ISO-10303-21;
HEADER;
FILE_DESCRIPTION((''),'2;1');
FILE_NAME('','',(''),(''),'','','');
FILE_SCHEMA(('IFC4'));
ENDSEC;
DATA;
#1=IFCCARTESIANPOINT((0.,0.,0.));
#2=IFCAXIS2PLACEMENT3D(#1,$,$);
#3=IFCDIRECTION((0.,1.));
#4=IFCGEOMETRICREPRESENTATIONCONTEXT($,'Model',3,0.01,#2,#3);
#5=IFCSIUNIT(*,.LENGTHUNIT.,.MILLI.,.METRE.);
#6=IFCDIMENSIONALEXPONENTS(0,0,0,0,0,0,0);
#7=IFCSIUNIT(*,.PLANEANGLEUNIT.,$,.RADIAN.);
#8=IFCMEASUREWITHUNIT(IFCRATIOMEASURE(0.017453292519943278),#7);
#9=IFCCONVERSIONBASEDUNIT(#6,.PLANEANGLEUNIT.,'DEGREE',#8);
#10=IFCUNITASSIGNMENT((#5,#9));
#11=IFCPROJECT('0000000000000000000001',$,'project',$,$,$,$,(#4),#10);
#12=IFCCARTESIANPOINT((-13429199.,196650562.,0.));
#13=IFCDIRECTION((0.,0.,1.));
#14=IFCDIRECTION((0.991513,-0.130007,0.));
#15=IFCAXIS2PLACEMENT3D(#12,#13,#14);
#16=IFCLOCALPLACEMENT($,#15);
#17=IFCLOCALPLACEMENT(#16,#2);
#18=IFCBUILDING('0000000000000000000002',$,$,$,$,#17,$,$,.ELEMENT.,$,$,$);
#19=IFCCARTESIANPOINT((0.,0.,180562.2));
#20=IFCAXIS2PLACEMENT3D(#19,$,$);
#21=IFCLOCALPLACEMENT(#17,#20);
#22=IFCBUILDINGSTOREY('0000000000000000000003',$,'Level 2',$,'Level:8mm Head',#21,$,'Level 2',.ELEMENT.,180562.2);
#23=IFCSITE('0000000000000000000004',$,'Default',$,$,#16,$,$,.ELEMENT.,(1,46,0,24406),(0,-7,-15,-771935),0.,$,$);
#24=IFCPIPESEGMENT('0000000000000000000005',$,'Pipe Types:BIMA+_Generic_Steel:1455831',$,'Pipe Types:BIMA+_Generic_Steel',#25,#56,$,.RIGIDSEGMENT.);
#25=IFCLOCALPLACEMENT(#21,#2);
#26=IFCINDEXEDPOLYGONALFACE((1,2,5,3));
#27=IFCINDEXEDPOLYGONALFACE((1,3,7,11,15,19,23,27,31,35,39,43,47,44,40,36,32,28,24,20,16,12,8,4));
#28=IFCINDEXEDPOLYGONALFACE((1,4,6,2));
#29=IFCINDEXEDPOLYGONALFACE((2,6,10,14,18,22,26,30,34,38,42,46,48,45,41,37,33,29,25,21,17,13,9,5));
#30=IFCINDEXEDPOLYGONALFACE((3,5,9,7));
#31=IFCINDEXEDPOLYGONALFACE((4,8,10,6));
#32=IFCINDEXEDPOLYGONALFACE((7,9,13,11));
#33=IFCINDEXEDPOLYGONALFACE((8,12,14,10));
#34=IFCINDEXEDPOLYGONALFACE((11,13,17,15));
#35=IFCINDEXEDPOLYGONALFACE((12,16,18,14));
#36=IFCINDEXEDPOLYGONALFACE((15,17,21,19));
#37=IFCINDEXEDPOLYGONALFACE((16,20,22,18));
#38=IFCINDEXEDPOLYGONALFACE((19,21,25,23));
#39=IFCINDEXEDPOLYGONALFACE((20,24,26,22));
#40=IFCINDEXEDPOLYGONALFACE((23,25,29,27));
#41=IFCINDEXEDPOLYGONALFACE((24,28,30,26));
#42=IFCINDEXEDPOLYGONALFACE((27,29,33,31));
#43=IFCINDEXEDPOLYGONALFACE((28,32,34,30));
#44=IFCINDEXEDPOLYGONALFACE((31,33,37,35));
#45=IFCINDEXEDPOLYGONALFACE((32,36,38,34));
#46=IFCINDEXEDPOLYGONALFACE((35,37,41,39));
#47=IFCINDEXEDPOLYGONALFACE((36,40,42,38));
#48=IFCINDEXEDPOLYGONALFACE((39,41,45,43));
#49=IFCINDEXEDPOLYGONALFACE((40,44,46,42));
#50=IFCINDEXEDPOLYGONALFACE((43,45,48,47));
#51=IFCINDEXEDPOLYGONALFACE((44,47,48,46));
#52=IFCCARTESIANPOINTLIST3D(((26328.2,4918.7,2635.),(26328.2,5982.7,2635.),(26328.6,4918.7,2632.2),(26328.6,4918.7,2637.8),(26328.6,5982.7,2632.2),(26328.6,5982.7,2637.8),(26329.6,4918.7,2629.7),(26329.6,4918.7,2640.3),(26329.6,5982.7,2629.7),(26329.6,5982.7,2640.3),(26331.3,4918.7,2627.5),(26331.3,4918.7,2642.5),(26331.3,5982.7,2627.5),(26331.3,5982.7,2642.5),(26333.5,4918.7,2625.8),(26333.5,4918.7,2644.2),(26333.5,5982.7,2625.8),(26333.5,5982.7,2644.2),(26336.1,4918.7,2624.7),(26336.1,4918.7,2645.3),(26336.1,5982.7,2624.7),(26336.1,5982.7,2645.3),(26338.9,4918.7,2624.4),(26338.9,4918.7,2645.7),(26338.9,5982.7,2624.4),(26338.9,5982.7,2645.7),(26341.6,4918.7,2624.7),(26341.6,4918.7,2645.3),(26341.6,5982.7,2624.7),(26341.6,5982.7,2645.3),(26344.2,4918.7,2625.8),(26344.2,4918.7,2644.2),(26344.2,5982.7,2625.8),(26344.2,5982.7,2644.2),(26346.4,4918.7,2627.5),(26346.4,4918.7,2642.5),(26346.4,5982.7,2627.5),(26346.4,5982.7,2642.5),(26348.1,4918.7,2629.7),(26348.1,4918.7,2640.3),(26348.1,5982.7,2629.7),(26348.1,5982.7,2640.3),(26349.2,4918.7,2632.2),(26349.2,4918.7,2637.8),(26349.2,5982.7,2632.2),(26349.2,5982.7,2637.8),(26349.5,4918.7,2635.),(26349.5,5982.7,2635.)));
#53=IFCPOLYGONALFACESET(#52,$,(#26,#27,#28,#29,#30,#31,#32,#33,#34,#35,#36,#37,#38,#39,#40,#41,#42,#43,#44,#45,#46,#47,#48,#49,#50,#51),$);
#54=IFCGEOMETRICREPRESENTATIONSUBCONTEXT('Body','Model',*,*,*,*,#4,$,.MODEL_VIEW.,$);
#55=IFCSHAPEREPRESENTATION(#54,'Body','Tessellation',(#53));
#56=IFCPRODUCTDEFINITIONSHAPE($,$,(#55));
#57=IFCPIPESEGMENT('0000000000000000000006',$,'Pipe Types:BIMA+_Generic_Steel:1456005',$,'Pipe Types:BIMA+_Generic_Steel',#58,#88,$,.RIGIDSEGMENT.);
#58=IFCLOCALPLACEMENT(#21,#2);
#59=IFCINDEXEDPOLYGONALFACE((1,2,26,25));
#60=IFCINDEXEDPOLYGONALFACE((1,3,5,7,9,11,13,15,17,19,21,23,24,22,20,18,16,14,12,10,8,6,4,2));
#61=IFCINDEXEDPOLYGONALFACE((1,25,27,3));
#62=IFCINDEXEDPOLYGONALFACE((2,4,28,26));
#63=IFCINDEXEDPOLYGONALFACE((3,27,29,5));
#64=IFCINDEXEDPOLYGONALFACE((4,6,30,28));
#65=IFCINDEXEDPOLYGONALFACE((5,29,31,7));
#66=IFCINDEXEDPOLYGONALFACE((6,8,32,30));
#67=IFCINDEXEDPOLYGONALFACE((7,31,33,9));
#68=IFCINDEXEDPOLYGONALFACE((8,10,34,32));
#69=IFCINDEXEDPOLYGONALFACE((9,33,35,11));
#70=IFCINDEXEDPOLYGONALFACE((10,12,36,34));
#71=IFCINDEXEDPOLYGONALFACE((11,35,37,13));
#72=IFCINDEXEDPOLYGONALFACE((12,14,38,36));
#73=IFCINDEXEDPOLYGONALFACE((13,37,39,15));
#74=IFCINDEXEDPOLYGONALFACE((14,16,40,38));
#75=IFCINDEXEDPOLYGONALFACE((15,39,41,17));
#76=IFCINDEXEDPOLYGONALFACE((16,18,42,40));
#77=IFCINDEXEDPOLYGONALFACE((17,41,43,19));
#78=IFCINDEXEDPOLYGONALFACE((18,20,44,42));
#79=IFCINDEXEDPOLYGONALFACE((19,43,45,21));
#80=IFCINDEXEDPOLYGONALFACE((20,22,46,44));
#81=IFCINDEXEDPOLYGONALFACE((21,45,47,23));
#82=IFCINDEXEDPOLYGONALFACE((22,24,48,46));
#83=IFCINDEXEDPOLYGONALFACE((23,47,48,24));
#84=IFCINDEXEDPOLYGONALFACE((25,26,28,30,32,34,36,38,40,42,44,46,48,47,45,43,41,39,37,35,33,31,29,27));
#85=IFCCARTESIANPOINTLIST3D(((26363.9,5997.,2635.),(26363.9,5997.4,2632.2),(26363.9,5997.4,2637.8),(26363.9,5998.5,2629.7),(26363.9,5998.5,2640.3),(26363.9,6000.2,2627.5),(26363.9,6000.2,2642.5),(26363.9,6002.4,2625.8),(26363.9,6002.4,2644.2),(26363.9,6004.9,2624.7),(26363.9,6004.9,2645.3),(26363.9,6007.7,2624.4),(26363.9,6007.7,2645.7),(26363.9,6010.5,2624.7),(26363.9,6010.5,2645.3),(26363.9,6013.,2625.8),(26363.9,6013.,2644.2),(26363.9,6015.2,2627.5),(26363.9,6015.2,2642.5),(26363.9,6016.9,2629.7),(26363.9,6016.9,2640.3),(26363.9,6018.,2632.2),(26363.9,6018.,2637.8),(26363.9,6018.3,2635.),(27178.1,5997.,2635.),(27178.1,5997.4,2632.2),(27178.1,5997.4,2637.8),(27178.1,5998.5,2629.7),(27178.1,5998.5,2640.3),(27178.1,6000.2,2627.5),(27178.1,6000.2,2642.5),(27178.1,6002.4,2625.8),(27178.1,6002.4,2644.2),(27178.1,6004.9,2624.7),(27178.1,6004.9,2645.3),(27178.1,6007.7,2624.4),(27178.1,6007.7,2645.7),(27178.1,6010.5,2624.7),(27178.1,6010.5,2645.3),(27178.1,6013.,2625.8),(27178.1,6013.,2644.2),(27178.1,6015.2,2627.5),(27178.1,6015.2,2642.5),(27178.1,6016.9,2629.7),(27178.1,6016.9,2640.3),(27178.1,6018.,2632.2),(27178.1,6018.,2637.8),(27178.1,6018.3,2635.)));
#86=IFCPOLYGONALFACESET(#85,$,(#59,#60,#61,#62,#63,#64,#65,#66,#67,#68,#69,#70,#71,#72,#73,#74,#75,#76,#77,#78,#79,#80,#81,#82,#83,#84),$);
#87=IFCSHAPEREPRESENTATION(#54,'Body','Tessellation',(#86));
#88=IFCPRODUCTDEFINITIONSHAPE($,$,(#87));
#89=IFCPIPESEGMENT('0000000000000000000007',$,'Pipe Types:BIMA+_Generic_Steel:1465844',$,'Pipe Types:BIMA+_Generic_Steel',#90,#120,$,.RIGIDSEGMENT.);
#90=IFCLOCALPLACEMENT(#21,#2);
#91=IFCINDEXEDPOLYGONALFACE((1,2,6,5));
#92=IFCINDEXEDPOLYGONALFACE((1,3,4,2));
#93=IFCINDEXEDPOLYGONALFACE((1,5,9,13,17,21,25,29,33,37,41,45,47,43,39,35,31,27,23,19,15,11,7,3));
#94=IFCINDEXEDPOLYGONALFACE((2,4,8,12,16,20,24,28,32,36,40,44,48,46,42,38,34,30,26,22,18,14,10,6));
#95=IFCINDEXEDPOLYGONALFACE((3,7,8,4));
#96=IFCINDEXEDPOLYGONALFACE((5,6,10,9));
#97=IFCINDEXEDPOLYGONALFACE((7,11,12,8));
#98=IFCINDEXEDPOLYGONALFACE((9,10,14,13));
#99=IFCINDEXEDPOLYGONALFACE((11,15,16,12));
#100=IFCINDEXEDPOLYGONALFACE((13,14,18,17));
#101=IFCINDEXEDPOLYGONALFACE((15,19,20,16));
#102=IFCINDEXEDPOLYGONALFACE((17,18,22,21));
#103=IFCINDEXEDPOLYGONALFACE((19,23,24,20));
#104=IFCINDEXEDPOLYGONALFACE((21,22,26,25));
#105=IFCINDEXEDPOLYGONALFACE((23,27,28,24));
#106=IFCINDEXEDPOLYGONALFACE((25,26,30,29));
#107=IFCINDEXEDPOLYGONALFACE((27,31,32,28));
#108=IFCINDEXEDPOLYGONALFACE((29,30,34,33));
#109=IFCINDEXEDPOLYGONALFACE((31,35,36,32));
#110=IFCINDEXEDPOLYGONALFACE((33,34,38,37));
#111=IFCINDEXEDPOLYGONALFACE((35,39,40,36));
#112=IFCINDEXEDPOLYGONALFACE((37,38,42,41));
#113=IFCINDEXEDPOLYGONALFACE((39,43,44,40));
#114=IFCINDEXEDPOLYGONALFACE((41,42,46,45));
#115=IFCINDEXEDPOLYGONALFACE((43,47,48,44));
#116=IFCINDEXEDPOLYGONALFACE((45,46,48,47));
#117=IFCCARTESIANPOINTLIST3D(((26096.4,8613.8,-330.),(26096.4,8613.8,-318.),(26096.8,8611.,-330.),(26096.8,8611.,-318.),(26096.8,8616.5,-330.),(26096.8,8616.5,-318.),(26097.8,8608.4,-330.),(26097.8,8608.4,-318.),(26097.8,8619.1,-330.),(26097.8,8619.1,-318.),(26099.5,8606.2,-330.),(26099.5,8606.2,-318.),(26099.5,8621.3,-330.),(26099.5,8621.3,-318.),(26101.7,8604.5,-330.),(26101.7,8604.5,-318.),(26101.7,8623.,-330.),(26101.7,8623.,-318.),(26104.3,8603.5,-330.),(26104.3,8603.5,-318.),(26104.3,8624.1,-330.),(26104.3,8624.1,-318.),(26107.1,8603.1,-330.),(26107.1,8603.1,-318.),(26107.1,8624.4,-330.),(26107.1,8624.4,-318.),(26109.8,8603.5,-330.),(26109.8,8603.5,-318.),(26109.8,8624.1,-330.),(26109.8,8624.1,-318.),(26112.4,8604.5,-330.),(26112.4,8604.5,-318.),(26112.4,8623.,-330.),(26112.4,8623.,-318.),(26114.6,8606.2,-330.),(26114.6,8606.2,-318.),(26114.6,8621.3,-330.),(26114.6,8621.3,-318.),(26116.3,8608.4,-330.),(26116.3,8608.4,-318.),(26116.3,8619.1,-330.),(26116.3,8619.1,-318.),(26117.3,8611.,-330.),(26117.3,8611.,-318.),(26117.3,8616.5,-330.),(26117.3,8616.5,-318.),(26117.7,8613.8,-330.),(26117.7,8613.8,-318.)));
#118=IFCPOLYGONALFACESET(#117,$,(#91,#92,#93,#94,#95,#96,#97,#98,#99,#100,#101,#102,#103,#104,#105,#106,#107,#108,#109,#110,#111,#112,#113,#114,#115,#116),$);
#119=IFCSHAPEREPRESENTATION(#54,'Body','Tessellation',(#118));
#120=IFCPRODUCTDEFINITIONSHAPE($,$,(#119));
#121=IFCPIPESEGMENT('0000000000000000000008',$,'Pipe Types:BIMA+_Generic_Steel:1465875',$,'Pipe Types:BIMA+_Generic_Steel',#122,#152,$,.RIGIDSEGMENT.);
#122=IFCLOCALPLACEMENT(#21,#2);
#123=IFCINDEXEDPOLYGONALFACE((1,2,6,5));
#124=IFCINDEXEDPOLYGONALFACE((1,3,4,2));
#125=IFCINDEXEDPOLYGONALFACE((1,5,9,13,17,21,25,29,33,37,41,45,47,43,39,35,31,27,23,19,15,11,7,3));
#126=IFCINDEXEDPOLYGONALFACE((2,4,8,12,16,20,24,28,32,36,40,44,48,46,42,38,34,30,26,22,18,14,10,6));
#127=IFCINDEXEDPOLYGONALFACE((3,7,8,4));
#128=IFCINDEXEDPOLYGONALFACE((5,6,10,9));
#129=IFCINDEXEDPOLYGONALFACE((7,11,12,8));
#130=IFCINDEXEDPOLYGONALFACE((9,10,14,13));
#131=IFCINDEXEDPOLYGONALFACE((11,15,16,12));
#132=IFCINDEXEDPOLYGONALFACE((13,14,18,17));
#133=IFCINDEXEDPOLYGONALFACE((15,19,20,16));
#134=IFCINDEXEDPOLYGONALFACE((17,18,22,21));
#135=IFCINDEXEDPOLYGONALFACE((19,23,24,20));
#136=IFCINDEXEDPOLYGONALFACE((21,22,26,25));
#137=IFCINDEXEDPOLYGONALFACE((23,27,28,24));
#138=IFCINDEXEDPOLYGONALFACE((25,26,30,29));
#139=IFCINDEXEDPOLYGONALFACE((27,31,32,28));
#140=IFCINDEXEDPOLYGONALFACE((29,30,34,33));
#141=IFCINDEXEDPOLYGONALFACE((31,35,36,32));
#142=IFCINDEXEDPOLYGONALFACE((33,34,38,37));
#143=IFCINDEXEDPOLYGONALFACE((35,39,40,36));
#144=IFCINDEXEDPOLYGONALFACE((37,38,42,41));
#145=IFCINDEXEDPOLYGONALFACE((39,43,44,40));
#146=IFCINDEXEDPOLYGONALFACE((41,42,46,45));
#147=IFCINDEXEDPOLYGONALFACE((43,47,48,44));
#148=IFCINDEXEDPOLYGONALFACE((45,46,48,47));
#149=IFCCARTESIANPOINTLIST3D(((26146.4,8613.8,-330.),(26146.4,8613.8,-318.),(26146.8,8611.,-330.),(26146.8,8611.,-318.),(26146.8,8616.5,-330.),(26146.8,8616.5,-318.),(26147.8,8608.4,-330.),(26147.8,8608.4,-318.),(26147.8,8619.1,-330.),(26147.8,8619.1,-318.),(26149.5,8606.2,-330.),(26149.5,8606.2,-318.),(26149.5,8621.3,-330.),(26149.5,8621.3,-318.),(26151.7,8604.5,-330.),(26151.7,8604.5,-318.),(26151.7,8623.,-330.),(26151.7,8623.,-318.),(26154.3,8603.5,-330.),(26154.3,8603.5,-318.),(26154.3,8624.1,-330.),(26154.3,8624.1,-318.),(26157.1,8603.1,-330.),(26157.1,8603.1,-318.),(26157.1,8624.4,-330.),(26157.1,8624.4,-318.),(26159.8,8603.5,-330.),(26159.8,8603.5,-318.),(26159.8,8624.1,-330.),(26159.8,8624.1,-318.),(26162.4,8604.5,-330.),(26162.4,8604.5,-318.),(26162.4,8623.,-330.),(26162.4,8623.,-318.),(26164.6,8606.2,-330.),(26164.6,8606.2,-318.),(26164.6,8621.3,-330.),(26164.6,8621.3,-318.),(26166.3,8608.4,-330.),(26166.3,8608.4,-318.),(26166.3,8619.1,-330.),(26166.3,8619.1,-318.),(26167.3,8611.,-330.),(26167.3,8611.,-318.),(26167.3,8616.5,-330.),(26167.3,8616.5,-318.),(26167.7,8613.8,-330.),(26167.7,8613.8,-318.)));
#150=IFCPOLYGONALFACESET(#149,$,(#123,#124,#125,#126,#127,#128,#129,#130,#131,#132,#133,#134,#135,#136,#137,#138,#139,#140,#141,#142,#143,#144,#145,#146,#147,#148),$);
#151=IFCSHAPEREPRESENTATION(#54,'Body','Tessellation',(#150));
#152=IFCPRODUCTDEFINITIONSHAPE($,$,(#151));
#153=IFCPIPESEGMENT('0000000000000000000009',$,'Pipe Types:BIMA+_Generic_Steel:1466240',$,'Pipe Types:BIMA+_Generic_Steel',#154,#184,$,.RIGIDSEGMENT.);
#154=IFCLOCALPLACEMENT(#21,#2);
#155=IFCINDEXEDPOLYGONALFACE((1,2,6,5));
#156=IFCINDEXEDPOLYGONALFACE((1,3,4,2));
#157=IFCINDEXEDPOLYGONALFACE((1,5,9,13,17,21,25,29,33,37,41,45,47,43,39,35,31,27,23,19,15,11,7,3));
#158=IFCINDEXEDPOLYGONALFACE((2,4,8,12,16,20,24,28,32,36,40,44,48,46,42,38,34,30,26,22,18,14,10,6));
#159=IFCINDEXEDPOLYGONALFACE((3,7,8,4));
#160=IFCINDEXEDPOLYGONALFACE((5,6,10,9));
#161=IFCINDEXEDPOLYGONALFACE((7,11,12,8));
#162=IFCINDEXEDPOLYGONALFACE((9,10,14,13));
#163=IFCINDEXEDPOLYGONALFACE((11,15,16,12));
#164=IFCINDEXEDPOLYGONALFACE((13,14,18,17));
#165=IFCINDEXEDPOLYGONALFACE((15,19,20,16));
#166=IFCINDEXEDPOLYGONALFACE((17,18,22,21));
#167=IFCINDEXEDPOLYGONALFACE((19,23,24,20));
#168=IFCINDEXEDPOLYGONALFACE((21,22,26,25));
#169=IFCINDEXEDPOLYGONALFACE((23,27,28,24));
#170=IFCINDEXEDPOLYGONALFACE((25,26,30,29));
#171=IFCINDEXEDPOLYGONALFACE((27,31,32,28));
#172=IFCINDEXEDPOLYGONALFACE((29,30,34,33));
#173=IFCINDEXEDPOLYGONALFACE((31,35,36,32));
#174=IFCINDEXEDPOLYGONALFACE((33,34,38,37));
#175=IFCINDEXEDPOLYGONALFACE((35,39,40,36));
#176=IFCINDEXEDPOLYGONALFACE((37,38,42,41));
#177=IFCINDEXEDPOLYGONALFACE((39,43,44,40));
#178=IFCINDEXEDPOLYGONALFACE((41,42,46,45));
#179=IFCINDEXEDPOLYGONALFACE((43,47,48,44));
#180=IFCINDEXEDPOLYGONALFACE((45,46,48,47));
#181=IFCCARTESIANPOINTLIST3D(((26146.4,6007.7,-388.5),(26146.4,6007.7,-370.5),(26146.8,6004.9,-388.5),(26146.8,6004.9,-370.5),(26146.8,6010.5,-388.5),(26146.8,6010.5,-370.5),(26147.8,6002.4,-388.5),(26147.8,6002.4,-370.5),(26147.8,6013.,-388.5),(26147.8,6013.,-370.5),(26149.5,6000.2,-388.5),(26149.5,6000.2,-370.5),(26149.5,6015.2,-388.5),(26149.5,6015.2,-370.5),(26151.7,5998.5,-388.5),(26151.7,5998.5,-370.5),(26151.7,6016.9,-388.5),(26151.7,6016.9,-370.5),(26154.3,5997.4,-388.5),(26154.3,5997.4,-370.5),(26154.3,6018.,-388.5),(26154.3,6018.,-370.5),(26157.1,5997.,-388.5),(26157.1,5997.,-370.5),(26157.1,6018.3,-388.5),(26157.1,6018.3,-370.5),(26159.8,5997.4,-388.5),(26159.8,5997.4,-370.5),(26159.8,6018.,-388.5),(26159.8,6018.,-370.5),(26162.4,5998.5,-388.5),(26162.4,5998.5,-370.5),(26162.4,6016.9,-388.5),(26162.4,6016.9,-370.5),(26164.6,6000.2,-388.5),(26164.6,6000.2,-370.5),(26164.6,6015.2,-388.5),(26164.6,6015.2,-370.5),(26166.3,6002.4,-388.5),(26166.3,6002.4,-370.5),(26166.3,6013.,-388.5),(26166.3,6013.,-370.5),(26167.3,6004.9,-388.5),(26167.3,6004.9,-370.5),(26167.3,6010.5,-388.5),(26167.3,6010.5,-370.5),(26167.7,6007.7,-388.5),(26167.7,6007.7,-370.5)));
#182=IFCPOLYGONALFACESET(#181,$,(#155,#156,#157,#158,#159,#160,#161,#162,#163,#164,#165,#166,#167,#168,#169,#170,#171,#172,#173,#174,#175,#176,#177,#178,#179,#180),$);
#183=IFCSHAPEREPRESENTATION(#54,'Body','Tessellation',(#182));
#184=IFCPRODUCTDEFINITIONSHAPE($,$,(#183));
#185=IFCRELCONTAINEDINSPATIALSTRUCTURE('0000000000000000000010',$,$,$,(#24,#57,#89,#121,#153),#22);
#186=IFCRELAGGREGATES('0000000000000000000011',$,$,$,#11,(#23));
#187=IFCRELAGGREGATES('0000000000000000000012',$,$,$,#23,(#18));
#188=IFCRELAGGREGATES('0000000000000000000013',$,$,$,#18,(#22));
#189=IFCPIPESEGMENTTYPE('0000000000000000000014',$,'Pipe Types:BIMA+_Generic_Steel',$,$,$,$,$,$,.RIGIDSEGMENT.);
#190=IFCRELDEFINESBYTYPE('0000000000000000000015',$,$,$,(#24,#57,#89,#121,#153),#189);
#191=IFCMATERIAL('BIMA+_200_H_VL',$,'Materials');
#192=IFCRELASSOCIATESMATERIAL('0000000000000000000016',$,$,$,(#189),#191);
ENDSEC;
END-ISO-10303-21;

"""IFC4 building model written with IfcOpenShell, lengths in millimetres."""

from ifc_helpers import new_model, entity, si_unit, converted_unit, direction, frame, origin, place, context, subcontext, project, spatial, arc, indexed_curve, outline, extrude, material, type_object, element, save


model = new_model("IFC4")

# Units and contexts
model_context = context("Model", 3, precision=0.01, world=origin(), true_north=direction((0.0, 1.0)))
body_context = subcontext(model_context, "Body", "Model", "MODEL_VIEW")
ifc_project = project(units=[si_unit("LENGTHUNIT", "METRE", prefix="MILLI"), converted_unit("PLANEANGLEUNIT", "DEGREE", entity("IfcRatioMeasure", 0.017453292519943278), si_unit("PLANEANGLEUNIT", "RADIAN"), dimensions=[0, 0, 0, 0, 0, 0, 0])], contexts=[model_context])

# Site, building, storey
site_placement = place(None, frame((-13429199.0, 196650562.0, 0.0), z_axis=(0.0, 0.0, 1.0), x_axis=(0.991513, -0.130007, 0.0)))
site = spatial("IfcSite", under=ifc_project, at=site_placement, Name="Default", CompositionType="ELEMENT", RefLatitude=(1, 46, 0, 24406), RefLongitude=(0, -7, -15, -771935), RefElevation=0.0)
building_placement = place(site_placement, origin())
building = spatial("IfcBuilding", under=site, at=building_placement, CompositionType="ELEMENT")
storey_placement = place(building_placement, frame((0.0, 0.0, 180562.2)))
storey = spatial("IfcBuildingStorey", under=building, at=storey_placement, Name="Level 2", ObjectType="Level:8mm Head", LongName="Level 2", CompositionType="ELEMENT", Elevation=180562.2)

# Pipe segments
ifc_material_1 = material(Name="BIMA+_200_H_VL", Category="Materials")
pipe_segment_type = type_object("IfcPipeSegmentType", Name="Pipe Types:BIMA+_Generic_Steel", PredefinedType="RIGIDSEGMENT", material=ifc_material_1)
pipe_segment_1_placement = place(storey_placement, frame((26326.6, 4918.7, 2622.8)))
element("IfcPipeSegment", 1, at=pipe_segment_1_placement, inside=storey, type_object=pipe_segment_type, Name="Pipe Types:BIMA+_Generic_Steel:1455831", ObjectType="Pipe Types:BIMA+_Generic_Steel", PredefinedType="RIGIDSEGMENT", context=body_context, shape_type="SweptSolid", body=[
    extrude(outline(indexed_curve([(10.7, 0.0), (7.5, 7.5), (0.0, 10.7), (-7.5, 7.5), (-10.7, 0.0), (-7.5, -7.5), (0.0, -10.7), (7.5, -7.5)], segments=[arc(1, 2, 3), arc(3, 4, 5), arc(5, 6, 7), arc(7, 8, 1)], self_intersect=False)), frame((12.2, 0.0, 12.2), z_axis=(0.0, 1.0, 0.0), x_axis=(-1.0, 0.0, 0.0)), (0.0, 0.0, 1.0), 1064.0),
])
pipe_segment_2_placement = place(storey_placement, frame((26363.9, 5995.5, 2622.8)))
element("IfcPipeSegment", 2, at=pipe_segment_2_placement, inside=storey, type_object=pipe_segment_type, Name="Pipe Types:BIMA+_Generic_Steel:1456005", ObjectType="Pipe Types:BIMA+_Generic_Steel", PredefinedType="RIGIDSEGMENT", context=body_context, shape_type="SweptSolid", body=[
    extrude(outline(indexed_curve([(10.6, 0.0), (7.5, 7.5), (0.0, 10.7), (-7.5, 7.5), (-10.6, 0.0), (-7.5, -7.5), (0.0, -10.7), (7.5, -7.5)], segments=[arc(1, 2, 3), arc(3, 4, 5), arc(5, 6, 7), arc(7, 8, 1)], self_intersect=False)), frame((0.0, 12.2, 12.2), z_axis=(1.0, 0.0, 0.0), x_axis=(0.0, 1.0, 0.0)), (0.0, 0.0, 1.0), 814.2),
])
for number, where, name in (
    (3, (26094.8, 8601.5, -330.0), "Pipe Types:BIMA+_Generic_Steel:1465844"),
    (4, (26144.8, 8601.5, -330.0), "Pipe Types:BIMA+_Generic_Steel:1465875"),
):
    element("IfcPipeSegment", number, at=place(storey_placement, frame(where)), inside=storey, type_object=pipe_segment_type, Name=name, ObjectType="Pipe Types:BIMA+_Generic_Steel", PredefinedType="RIGIDSEGMENT", context=body_context, shape_type="SweptSolid", body=[
        extrude(outline(indexed_curve([(10.7, 0.0), (7.5, 7.5), (0.0, 10.6), (-7.5, 7.5), (-10.7, 0.0), (-7.5, -7.5), (0.0, -10.6), (7.5, -7.5)], segments=[arc(1, 2, 3), arc(3, 4, 5), arc(5, 6, 7), arc(7, 8, 1)], self_intersect=False)), frame((12.2, 12.2, 0.0), z_axis=(0.0, 0.0, 1.0), x_axis=(-1.0, 0.0, 0.0)), (0.0, 0.0, 1.0), 12.0),
    ])
pipe_segment_3_placement = place(storey_placement, frame((26144.8, 5995.5, -370.5)))
element("IfcPipeSegment", 5, at=pipe_segment_3_placement, inside=storey, type_object=pipe_segment_type, Name="Pipe Types:BIMA+_Generic_Steel:1466240", ObjectType="Pipe Types:BIMA+_Generic_Steel", PredefinedType="RIGIDSEGMENT", context=body_context, shape_type="SweptSolid", body=[
    extrude(outline(indexed_curve([(10.7, 0.0), (7.5, 7.5), (0.0, 10.6), (-7.5, 7.5), (-10.7, 0.0), (-7.5, -7.5), (0.0, -10.6), (7.5, -7.5)], segments=[arc(1, 2, 3), arc(3, 4, 5), arc(5, 6, 7), arc(7, 8, 1)], self_intersect=False)), frame((12.2, 12.2, -18.0), z_axis=(0.0, 0.0, 1.0), x_axis=(-1.0, 0.0, 0.0)), (0.0, 0.0, 1.0), 18.0),
])

save(model, "model.ifc")
